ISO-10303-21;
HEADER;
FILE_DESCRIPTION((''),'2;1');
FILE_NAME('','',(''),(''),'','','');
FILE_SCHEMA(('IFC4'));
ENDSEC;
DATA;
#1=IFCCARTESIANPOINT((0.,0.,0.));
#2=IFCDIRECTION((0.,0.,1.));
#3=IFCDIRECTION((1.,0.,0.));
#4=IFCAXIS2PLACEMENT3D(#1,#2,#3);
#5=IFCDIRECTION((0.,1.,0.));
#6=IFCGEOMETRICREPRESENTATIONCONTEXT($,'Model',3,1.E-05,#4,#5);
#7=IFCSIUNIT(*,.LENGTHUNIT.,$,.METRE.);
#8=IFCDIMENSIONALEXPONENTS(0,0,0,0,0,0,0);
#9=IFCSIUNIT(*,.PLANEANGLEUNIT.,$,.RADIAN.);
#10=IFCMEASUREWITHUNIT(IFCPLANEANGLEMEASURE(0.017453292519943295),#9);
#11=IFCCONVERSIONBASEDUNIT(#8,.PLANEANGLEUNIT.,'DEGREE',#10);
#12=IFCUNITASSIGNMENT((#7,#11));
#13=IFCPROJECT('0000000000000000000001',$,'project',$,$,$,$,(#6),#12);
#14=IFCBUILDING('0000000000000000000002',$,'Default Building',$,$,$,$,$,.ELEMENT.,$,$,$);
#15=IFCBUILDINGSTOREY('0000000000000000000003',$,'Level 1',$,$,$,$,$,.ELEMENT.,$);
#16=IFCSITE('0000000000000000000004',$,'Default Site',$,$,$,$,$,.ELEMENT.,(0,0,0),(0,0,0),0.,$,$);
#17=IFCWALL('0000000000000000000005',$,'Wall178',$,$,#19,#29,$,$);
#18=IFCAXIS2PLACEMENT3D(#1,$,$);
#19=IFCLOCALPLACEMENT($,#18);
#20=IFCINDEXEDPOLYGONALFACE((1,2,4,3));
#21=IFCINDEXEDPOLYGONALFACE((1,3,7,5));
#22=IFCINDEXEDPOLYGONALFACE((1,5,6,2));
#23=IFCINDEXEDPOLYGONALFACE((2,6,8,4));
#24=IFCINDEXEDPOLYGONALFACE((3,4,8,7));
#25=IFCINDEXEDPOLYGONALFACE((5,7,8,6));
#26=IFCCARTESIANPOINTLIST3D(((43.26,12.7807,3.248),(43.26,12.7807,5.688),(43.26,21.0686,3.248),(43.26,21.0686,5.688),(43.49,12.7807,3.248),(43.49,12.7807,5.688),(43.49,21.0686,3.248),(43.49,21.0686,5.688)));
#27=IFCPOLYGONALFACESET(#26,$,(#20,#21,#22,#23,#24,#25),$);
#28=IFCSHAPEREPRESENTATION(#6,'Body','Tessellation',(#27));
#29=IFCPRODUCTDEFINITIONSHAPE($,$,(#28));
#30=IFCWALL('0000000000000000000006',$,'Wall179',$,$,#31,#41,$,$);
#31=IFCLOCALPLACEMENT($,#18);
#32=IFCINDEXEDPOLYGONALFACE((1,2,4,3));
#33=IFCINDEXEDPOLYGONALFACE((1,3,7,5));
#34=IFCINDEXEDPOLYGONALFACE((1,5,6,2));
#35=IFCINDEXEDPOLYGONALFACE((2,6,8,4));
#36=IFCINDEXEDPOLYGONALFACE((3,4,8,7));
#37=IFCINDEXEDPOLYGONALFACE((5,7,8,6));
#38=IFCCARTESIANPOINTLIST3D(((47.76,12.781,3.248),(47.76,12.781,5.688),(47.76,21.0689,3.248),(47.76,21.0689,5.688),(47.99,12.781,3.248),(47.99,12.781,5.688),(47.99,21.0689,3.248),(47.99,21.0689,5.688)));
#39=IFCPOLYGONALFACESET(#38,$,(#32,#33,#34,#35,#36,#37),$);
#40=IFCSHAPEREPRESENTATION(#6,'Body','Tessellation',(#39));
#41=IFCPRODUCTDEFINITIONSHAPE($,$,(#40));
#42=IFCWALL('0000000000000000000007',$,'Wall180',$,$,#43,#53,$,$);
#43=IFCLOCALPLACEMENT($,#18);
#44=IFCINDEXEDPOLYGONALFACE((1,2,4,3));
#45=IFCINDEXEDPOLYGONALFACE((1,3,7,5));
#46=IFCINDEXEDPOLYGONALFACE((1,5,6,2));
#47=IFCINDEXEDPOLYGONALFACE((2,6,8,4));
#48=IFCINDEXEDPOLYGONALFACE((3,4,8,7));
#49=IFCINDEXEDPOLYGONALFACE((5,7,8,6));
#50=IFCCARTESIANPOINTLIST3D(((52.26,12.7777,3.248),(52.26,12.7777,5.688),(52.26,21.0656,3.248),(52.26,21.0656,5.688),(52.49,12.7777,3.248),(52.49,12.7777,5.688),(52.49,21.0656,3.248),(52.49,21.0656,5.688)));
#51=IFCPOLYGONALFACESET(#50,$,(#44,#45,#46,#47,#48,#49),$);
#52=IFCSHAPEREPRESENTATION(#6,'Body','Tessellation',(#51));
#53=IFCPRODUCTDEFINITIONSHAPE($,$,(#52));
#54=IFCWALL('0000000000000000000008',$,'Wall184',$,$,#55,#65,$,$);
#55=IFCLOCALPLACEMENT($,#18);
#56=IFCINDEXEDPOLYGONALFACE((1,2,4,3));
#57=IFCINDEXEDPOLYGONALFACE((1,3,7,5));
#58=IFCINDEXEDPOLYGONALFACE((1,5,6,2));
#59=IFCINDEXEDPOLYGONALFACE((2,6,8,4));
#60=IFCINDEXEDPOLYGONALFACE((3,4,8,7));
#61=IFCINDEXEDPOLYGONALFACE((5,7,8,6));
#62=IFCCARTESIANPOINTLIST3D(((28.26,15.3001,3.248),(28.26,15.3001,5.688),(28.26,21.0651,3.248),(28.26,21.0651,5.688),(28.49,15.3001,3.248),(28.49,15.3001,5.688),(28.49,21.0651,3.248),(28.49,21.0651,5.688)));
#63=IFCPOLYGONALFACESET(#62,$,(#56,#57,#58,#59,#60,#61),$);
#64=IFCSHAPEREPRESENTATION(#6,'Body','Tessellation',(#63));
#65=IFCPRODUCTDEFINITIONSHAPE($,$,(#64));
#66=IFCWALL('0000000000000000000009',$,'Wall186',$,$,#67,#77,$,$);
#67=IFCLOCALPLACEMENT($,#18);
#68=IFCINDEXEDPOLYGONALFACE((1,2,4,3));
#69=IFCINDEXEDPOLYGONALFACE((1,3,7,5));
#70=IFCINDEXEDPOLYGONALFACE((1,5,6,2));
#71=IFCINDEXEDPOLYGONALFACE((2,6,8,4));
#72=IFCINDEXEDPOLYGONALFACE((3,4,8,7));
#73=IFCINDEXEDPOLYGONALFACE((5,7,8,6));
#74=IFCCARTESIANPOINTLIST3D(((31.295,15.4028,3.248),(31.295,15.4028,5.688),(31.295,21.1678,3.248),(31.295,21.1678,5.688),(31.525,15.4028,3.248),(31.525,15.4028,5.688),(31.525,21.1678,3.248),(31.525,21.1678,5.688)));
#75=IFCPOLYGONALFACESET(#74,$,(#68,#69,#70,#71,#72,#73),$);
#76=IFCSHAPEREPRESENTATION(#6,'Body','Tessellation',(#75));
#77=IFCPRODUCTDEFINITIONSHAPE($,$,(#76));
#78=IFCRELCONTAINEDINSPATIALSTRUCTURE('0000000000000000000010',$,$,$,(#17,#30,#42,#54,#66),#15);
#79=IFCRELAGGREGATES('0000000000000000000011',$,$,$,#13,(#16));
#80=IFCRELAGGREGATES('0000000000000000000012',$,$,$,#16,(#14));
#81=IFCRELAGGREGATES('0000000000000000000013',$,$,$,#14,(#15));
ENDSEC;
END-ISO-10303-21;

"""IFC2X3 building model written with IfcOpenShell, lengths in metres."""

from ifc_helpers import new_model, entity, si_unit, converted_unit, direction, frame, frame_2d, origin_with_axes, place, context, project, spatial, rectangle, extrude, element, save


model = new_model("IFC2X3")

# Units and contexts
model_context = context("Model", 3, precision=1e-05, world=origin_with_axes(), true_north=direction((0.0, 1.0, 0.0)))
ifc_project = project(units=[si_unit("LENGTHUNIT", "METRE"), converted_unit("PLANEANGLEUNIT", "DEGREE", entity("IfcPlaneAngleMeasure", 0.017453292519943295), si_unit("PLANEANGLEUNIT", "RADIAN"), dimensions=[0, 0, 0, 0, 0, 0, 0])], contexts=[model_context])

# Site, building, storey
site = spatial("IfcSite", under=ifc_project, Name="Default Site", CompositionType="ELEMENT", RefLatitude=(0, 0, 0), RefLongitude=(0, 0, 0), RefElevation=0.0)
building = spatial("IfcBuilding", under=site, Name="Default Building", CompositionType="ELEMENT")
storey = spatial("IfcBuildingStorey", under=building, Name="Level 1", CompositionType="ELEMENT")

# Shared definitions
placement = place(None, origin_with_axes())

# Walls
element("IfcWall", 1, at=placement, inside=storey, Name="Wall178", context=model_context, shape_type="SweptSolid", body=[
    extrude(rectangle(XDim=8.2879, YDim=0.23, at=frame_2d((0.0, 0.0), x_axis=(0.0, 1.0, 0.0))), frame((43.375, 16.9246, 3.248), z_axis=(0.0, 0.0, 1.0), x_axis=(1.0, 0.0, 0.0)), (0.0, 0.0, 1.0), 2.44),
])
element("IfcWall", 2, at=placement, inside=storey, Name="Wall179", context=model_context, shape_type="SweptSolid", body=[
    extrude(rectangle(XDim=8.2879, YDim=0.23, at=frame_2d((0.0, 0.0), x_axis=(0.0, 1.0, 0.0))), frame((47.875, 16.925, 3.248), z_axis=(0.0, 0.0, 1.0), x_axis=(1.0, 0.0, 0.0)), (0.0, 0.0, 1.0), 2.44),
])
element("IfcWall", 3, at=placement, inside=storey, Name="Wall180", context=model_context, shape_type="SweptSolid", body=[
    extrude(rectangle(XDim=8.2879, YDim=0.23, at=frame_2d((0.0, 0.0), x_axis=(0.0, 1.0, 0.0))), frame((52.375, 16.9216, 3.248), z_axis=(0.0, 0.0, 1.0), x_axis=(1.0, 0.0, 0.0)), (0.0, 0.0, 1.0), 2.44),
])
element("IfcWall", 4, at=placement, inside=storey, Name="Wall184", context=model_context, shape_type="SweptSolid", body=[
    extrude(rectangle(XDim=5.765, YDim=0.23, at=frame_2d((0.0, 0.0), x_axis=(0.0, 1.0, 0.0))), frame((28.375, 18.1826, 3.248), z_axis=(0.0, 0.0, 1.0), x_axis=(1.0, 0.0, 0.0)), (0.0, 0.0, 1.0), 2.44),
])
element("IfcWall", 5, at=placement, inside=storey, Name="Wall186", context=model_context, shape_type="SweptSolid", body=[
    extrude(rectangle(XDim=5.765, YDim=0.23, at=frame_2d((0.0, 0.0), x_axis=(0.0, 1.0, 0.0))), frame((31.41, 18.2853, 3.248), z_axis=(0.0, 0.0, 1.0), x_axis=(1.0, 0.0, 0.0)), (0.0, 0.0, 1.0), 2.44),
])

save(model, "model.ifc")
